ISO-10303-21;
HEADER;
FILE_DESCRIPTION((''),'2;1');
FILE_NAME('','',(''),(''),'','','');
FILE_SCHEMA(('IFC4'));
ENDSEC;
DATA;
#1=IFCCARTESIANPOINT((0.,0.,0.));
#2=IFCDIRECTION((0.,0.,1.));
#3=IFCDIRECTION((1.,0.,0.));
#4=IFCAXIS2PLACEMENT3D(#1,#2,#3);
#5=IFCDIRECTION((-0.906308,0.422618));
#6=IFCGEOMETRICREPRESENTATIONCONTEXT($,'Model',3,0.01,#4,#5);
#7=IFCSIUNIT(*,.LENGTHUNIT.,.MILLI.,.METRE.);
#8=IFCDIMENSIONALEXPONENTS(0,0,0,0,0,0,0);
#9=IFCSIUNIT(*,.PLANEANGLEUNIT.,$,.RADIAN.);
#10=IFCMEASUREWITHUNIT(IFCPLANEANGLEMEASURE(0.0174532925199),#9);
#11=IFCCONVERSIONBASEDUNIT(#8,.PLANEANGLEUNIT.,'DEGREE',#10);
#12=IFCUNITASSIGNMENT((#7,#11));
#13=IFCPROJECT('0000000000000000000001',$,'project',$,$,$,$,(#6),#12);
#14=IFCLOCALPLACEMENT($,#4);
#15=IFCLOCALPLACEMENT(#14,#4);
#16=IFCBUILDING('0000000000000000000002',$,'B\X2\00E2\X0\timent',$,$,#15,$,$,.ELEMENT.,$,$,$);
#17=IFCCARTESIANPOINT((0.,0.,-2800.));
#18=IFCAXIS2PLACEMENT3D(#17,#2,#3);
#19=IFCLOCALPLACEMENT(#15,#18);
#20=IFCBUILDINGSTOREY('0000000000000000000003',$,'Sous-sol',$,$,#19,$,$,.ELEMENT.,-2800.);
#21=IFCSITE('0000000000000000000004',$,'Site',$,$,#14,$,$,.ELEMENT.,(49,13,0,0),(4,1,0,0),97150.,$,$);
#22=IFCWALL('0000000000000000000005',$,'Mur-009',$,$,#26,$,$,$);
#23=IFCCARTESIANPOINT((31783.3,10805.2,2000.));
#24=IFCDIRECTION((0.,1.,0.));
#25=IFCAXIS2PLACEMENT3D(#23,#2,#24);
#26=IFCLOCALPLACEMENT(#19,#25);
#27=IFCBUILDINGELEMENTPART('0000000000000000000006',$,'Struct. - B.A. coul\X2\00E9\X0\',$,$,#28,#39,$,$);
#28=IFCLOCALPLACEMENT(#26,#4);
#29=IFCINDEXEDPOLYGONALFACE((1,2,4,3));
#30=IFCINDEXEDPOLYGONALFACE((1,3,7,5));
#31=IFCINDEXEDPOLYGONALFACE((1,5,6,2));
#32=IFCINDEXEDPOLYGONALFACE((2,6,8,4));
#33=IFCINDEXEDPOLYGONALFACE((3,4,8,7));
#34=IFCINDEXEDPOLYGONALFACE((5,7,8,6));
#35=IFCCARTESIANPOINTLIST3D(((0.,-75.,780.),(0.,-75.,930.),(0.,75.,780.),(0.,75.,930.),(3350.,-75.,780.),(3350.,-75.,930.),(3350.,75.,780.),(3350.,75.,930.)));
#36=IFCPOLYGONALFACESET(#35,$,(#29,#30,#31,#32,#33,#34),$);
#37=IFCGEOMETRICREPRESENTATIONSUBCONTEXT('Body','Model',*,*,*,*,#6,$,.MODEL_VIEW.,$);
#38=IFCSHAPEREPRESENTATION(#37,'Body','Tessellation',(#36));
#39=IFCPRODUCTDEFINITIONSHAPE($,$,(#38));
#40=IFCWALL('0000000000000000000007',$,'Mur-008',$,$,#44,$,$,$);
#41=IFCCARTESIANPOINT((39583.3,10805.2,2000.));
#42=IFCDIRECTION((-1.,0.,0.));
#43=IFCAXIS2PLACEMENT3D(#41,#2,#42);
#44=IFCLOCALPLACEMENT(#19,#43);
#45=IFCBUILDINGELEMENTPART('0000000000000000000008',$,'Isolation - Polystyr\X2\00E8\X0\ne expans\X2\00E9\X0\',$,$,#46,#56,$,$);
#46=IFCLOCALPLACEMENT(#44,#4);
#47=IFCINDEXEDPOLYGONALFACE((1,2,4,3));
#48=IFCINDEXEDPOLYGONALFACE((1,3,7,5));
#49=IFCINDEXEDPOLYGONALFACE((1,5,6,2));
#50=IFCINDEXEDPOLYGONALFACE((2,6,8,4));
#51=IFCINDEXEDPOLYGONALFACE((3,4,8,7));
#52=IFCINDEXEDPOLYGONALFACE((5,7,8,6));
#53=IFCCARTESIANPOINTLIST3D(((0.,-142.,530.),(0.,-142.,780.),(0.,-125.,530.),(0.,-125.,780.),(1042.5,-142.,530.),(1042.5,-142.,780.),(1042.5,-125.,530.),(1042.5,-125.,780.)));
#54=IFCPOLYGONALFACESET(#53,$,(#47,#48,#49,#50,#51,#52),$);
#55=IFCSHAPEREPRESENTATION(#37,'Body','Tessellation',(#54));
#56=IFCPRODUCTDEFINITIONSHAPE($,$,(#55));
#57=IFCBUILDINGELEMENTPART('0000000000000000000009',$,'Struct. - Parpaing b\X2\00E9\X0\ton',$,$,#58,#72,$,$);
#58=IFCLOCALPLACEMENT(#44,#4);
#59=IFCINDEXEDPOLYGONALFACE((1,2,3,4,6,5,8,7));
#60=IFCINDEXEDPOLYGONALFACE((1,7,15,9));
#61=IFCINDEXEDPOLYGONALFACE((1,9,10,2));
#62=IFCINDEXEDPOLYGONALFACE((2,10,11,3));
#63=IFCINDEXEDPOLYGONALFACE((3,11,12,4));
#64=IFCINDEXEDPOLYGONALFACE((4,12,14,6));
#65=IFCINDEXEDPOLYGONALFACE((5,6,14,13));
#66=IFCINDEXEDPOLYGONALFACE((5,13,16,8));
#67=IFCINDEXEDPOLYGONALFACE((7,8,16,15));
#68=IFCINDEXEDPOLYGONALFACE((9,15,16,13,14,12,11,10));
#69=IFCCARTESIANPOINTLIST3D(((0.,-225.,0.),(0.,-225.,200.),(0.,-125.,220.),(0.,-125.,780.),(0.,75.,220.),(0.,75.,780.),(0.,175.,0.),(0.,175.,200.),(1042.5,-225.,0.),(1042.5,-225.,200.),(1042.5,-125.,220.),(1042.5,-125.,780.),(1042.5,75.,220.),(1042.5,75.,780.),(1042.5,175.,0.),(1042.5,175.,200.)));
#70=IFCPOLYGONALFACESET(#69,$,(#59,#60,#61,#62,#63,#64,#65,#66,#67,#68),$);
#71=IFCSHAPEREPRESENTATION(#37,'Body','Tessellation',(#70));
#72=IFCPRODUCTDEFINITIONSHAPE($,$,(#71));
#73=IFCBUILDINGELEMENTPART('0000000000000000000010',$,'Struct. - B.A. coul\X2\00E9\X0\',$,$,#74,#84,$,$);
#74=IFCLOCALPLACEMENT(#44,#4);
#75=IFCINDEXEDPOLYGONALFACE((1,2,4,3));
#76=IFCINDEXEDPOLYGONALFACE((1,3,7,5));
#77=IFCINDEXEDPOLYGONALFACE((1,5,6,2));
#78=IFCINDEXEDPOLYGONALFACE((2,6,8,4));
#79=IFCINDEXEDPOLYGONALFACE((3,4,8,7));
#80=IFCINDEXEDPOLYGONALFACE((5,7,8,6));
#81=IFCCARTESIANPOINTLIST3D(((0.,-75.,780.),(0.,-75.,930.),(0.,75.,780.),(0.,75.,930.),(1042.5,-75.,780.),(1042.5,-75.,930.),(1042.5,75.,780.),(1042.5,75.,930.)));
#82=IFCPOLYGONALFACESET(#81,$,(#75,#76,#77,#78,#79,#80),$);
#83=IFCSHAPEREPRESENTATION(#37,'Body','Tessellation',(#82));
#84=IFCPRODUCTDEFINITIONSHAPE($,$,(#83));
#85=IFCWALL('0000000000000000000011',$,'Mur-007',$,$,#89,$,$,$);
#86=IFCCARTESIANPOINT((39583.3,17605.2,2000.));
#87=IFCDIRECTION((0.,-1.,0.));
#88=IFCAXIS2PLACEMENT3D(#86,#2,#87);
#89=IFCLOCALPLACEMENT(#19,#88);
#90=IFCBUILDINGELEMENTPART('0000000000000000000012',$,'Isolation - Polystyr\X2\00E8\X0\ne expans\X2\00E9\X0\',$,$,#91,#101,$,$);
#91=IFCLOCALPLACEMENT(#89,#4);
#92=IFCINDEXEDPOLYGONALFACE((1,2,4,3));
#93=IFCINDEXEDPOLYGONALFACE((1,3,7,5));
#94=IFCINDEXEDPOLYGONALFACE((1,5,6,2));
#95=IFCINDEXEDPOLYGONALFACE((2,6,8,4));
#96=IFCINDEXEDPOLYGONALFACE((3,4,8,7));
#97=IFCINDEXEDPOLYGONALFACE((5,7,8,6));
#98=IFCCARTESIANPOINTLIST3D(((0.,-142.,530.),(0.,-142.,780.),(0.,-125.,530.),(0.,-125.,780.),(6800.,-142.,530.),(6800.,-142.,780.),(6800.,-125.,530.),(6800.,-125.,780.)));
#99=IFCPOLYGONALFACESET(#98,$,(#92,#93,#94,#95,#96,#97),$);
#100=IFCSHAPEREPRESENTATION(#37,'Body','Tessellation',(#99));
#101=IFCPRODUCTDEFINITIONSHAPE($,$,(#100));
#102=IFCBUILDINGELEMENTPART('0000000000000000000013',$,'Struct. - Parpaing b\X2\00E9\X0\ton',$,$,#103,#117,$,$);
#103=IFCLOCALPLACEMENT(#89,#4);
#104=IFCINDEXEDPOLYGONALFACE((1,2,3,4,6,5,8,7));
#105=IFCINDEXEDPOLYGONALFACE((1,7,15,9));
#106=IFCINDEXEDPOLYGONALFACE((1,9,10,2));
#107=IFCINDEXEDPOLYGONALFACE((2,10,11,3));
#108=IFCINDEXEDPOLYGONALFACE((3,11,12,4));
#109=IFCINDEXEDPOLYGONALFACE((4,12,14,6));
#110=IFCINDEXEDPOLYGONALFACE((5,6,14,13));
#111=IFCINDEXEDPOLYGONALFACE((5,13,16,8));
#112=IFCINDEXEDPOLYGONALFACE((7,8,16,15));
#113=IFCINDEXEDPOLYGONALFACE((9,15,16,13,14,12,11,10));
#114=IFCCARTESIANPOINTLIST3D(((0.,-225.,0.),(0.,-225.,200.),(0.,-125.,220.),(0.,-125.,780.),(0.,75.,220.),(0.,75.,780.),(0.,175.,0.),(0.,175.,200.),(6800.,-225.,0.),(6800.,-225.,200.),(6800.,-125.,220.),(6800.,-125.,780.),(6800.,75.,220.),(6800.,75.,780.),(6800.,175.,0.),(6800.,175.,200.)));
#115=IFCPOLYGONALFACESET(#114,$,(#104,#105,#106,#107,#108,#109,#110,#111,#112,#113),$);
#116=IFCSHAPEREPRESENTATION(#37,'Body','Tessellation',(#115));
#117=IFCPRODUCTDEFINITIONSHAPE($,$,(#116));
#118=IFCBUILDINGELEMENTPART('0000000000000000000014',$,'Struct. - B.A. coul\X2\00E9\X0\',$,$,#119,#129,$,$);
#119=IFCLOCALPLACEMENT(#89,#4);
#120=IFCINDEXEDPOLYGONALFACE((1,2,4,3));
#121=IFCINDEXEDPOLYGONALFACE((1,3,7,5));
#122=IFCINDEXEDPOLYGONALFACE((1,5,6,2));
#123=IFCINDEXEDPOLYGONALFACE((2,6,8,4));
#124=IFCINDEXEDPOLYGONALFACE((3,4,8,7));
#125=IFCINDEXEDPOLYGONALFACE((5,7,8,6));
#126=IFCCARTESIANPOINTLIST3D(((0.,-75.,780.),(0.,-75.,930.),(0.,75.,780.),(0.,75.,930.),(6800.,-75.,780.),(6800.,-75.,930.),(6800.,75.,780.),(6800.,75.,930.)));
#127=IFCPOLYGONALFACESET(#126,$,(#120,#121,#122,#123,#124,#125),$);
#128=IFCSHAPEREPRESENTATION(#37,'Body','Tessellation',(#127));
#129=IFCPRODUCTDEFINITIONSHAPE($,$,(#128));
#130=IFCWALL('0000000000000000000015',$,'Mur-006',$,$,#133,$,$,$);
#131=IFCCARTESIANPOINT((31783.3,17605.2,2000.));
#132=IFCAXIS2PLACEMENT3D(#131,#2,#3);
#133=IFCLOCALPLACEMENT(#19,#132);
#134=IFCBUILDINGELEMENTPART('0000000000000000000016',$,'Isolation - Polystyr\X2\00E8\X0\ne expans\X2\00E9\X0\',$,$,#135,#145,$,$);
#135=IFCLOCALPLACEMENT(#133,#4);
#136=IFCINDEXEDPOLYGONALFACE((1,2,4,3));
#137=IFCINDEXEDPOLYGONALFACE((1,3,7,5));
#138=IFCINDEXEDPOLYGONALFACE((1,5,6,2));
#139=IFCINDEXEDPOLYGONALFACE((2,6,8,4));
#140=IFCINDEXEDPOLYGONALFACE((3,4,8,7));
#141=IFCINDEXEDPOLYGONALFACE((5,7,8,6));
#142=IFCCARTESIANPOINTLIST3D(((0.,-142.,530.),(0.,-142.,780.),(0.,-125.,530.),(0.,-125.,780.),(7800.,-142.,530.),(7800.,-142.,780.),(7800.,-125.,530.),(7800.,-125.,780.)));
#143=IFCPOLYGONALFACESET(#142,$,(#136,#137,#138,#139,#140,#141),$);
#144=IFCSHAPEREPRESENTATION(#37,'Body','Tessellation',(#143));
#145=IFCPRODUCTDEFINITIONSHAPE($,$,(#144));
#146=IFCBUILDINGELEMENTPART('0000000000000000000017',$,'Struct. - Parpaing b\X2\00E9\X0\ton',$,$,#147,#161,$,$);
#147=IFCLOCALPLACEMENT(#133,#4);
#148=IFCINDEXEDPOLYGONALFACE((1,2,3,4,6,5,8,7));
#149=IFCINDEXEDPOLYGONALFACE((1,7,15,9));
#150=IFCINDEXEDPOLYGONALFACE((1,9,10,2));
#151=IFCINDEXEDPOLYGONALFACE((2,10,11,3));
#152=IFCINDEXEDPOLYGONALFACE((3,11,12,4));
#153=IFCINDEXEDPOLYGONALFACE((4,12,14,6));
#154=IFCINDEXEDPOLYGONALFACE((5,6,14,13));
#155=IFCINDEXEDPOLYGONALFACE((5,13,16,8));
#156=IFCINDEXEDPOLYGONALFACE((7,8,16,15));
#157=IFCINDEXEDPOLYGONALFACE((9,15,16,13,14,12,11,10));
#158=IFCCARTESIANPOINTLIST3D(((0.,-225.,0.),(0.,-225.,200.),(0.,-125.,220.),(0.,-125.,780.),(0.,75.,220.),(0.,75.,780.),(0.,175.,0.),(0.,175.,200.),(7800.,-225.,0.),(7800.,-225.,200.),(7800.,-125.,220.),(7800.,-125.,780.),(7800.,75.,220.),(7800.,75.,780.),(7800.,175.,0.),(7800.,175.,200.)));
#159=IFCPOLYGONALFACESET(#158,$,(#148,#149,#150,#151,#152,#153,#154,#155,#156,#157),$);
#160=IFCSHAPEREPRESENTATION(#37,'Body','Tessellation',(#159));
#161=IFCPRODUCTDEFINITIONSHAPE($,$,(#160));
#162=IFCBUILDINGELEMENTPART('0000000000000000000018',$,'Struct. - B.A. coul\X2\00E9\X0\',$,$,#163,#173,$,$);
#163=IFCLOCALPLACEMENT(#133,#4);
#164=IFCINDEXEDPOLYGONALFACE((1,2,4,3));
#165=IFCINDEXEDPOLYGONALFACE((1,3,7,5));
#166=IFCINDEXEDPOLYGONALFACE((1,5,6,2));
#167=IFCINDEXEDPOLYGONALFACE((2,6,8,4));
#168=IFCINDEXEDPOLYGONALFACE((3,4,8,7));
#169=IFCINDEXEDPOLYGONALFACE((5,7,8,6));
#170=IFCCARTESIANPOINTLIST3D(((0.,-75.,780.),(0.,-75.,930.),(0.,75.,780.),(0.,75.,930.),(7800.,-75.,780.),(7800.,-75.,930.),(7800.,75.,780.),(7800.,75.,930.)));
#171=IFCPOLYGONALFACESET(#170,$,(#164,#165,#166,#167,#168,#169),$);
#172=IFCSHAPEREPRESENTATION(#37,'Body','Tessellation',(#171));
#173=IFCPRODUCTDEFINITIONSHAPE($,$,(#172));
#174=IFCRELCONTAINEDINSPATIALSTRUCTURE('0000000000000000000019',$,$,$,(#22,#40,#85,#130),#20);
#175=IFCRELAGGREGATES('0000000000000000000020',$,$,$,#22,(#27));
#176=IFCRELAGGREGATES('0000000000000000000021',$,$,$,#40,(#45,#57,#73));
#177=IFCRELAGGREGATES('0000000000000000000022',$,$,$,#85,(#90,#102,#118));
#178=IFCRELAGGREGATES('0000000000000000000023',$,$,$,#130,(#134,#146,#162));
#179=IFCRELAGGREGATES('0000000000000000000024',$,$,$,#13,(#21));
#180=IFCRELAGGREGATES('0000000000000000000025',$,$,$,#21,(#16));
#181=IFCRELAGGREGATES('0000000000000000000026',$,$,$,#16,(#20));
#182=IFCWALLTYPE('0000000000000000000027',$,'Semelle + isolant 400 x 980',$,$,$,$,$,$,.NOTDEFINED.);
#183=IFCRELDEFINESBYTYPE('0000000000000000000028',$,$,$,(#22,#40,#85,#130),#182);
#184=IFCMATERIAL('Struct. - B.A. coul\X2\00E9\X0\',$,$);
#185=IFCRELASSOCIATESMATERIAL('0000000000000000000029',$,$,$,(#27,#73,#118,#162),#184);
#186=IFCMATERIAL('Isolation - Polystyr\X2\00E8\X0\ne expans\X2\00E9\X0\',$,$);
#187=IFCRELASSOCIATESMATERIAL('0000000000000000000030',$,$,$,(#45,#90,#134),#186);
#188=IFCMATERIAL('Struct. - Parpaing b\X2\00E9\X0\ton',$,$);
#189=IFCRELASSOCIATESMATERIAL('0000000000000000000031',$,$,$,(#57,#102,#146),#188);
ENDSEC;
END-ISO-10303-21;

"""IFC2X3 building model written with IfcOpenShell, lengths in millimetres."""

from ifc_helpers import new_model, entity, si_unit, converted_unit, direction, frame, origin_with_axes, place, context, subcontext, project, spatial, polyline, outline, extrude, material, type_object, element, aggregate, save


model = new_model("IFC2X3")

# Units and contexts
model_context = context("Model", 3, precision=0.01, world=origin_with_axes(), true_north=direction((-0.906308, 0.422618)))
body_context = subcontext(model_context, "Body", "Model", "MODEL_VIEW")
ifc_project = project(units=[si_unit("LENGTHUNIT", "METRE", prefix="MILLI"), converted_unit("PLANEANGLEUNIT", "DEGREE", entity("IfcPlaneAngleMeasure", 0.0174532925199), si_unit("PLANEANGLEUNIT", "RADIAN"), dimensions=[0, 0, 0, 0, 0, 0, 0])], contexts=[model_context])

# Site, building, storey
site_placement = place(None, origin_with_axes())
site = spatial("IfcSite", under=ifc_project, at=site_placement, Name="Site", CompositionType="ELEMENT", RefLatitude=(49, 13, 0, 0), RefLongitude=(4, 1, 0, 0), RefElevation=97150.0)
building_placement = place(site_placement, origin_with_axes())
building = spatial("IfcBuilding", under=site, at=building_placement, Name="Bâtiment", CompositionType="ELEMENT")
storey_placement = place(building_placement, frame((0.0, 0.0, -2800.0), z_axis=(0.0, 0.0, 1.0), x_axis=(1.0, 0.0, 0.0)))
storey = spatial("IfcBuildingStorey", under=building, at=storey_placement, Name="Sous-sol", CompositionType="ELEMENT", Elevation=-2800.0)

# Walls, building element parts
ifc_material_1 = material(Name="Isolation - Polystyrène expansé")
ifc_material_2 = material(Name="Struct. - Parpaing béton")
wall_type_1 = type_object("IfcWallType", Name="Semelle + isolant 400 x 980", PredefinedType="NOTDEFINED")
ifc_material_3 = material(Name="Struct. - B.A. coulé")
wall_1_placement = place(storey_placement, frame((31783.3, 10805.2, 2000.0), z_axis=(0.0, 0.0, 1.0), x_axis=(0.0, 1.0, 0.0)))
wall_1 = element("IfcWall", 1, at=wall_1_placement, inside=storey, type_object=wall_type_1, Name="Mur-009")
building_element_part_1_placement = place(wall_1_placement, origin_with_axes())
building_element_part_1 = element("IfcBuildingElementPart", 2, at=building_element_part_1_placement, material=ifc_material_3, Name="Struct. - B.A. coulé", context=body_context, shape_type="SweptSolid", body=[
    extrude(outline(polyline([(75.0, 780.0), (75.0, 930.0), (-75.0, 930.0), (-75.0, 780.0), (75.0, 780.0)])), frame((0.0, 0.0, 0.0), z_axis=(-1.0, 0.0, 0.0), x_axis=(0.0, -1.0, 0.0)), (0.0, 0.0, -1.0), 3350.0),
])
aggregate(wall_1, [building_element_part_1])
wall_2_placement = place(storey_placement, frame((39583.3, 10805.2, 2000.0), z_axis=(0.0, 0.0, 1.0), x_axis=(-1.0, 0.0, 0.0)))
wall_2 = element("IfcWall", 3, at=wall_2_placement, inside=storey, type_object=wall_type_1, Name="Mur-008")
building_element_part_2_placement = place(wall_2_placement, origin_with_axes())
building_element_part_2 = element("IfcBuildingElementPart", 4, at=building_element_part_2_placement, material=ifc_material_1, Name="Isolation - Polystyrène expansé", context=body_context, shape_type="SweptSolid", body=[
    extrude(outline(polyline([(125.0, 780.0), (125.0, 530.0), (142.0, 530.0), (142.0, 780.0), (125.0, 780.0)])), frame((0.0, 0.0, 0.0), z_axis=(-1.0, 0.0, 0.0), x_axis=(0.0, -1.0, 0.0)), (0.0, 0.0, -1.0), 1042.5),
])
building_element_part_3_placement = place(wall_2_placement, origin_with_axes())
building_element_part_3 = element("IfcBuildingElementPart", 5, at=building_element_part_3_placement, material=ifc_material_2, Name="Struct. - Parpaing béton", context=body_context, shape_type="SweptSolid", body=[
    extrude(outline(polyline([(-75.0, 220.0), (-175.0, 200.0), (-175.0, 0.0), (225.0, 0.0), (225.0, 200.0), (125.0, 220.0), (125.0, 780.0), (-75.0, 780.0), (-75.0, 220.0)])), frame((0.0, 0.0, 0.0), z_axis=(-1.0, 0.0, 0.0), x_axis=(0.0, -1.0, 0.0)), (0.0, 0.0, -1.0), 1042.5),
])
building_element_part_4_placement = place(wall_2_placement, origin_with_axes())
building_element_part_4 = element("IfcBuildingElementPart", 6, at=building_element_part_4_placement, material=ifc_material_3, Name="Struct. - B.A. coulé", context=body_context, shape_type="SweptSolid", body=[
    extrude(outline(polyline([(75.0, 780.0), (75.0, 930.0), (-75.0, 930.0), (-75.0, 780.0), (75.0, 780.0)])), frame((0.0, 0.0, 0.0), z_axis=(-1.0, 0.0, 0.0), x_axis=(0.0, -1.0, 0.0)), (0.0, 0.0, -1.0), 1042.5),
])
aggregate(wall_2, [building_element_part_2, building_element_part_3, building_element_part_4])
wall_3_placement = place(storey_placement, frame((39583.3, 17605.2, 2000.0), z_axis=(0.0, 0.0, 1.0), x_axis=(0.0, -1.0, 0.0)))
wall_3 = element("IfcWall", 7, at=wall_3_placement, inside=storey, type_object=wall_type_1, Name="Mur-007")
building_element_part_5_placement = place(wall_3_placement, origin_with_axes())
building_element_part_5 = element("IfcBuildingElementPart", 8, at=building_element_part_5_placement, material=ifc_material_1, Name="Isolation - Polystyrène expansé", context=body_context, shape_type="SweptSolid", body=[
    extrude(outline(polyline([(125.0, 780.0), (125.0, 530.0), (142.0, 530.0), (142.0, 780.0), (125.0, 780.0)])), frame((0.0, 0.0, 0.0), z_axis=(-1.0, 0.0, 0.0), x_axis=(0.0, -1.0, 0.0)), (0.0, 0.0, -1.0), 6800.0),
])
building_element_part_6_placement = place(wall_3_placement, origin_with_axes())
building_element_part_6 = element("IfcBuildingElementPart", 9, at=building_element_part_6_placement, material=ifc_material_2, Name="Struct. - Parpaing béton", context=body_context, shape_type="SweptSolid", body=[
    extrude(outline(polyline([(-75.0, 220.0), (-175.0, 200.0), (-175.0, 0.0), (225.0, 0.0), (225.0, 200.0), (125.0, 220.0), (125.0, 780.0), (-75.0, 780.0), (-75.0, 220.0)])), frame((0.0, 0.0, 0.0), z_axis=(-1.0, 0.0, 0.0), x_axis=(0.0, -1.0, 0.0)), (0.0, 0.0, -1.0), 6800.0),
])
building_element_part_7_placement = place(wall_3_placement, origin_with_axes())
building_element_part_7 = element("IfcBuildingElementPart", 10, at=building_element_part_7_placement, material=ifc_material_3, Name="Struct. - B.A. coulé", context=body_context, shape_type="SweptSolid", body=[
    extrude(outline(polyline([(75.0, 780.0), (75.0, 930.0), (-75.0, 930.0), (-75.0, 780.0), (75.0, 780.0)])), frame((0.0, 0.0, 0.0), z_axis=(-1.0, 0.0, 0.0), x_axis=(0.0, -1.0, 0.0)), (0.0, 0.0, -1.0), 6800.0),
])
aggregate(wall_3, [building_element_part_5, building_element_part_6, building_element_part_7])
wall_4_placement = place(storey_placement, frame((31783.3, 17605.2, 2000.0), z_axis=(0.0, 0.0, 1.0), x_axis=(1.0, 0.0, 0.0)))
wall_4 = element("IfcWall", 11, at=wall_4_placement, inside=storey, type_object=wall_type_1, Name="Mur-006")
building_element_part_8_placement = place(wall_4_placement, origin_with_axes())
building_element_part_8 = element("IfcBuildingElementPart", 12, at=building_element_part_8_placement, material=ifc_material_1, Name="Isolation - Polystyrène expansé", context=body_context, shape_type="SweptSolid", body=[
    extrude(outline(polyline([(125.0, 780.0), (125.0, 530.0), (142.0, 530.0), (142.0, 780.0), (125.0, 780.0)])), frame((0.0, 0.0, 0.0), z_axis=(-1.0, 0.0, 0.0), x_axis=(0.0, -1.0, 0.0)), (0.0, 0.0, -1.0), 7800.0),
])
building_element_part_9_placement = place(wall_4_placement, origin_with_axes())
building_element_part_9 = element("IfcBuildingElementPart", 13, at=building_element_part_9_placement, material=ifc_material_2, Name="Struct. - Parpaing béton", context=body_context, shape_type="SweptSolid", body=[
    extrude(outline(polyline([(-75.0, 220.0), (-175.0, 200.0), (-175.0, 0.0), (225.0, 0.0), (225.0, 200.0), (125.0, 220.0), (125.0, 780.0), (-75.0, 780.0), (-75.0, 220.0)])), frame((0.0, 0.0, 0.0), z_axis=(-1.0, 0.0, 0.0), x_axis=(0.0, -1.0, 0.0)), (0.0, 0.0, -1.0), 7800.0),
])
building_element_part_10_placement = place(wall_4_placement, origin_with_axes())
building_element_part_10 = element("IfcBuildingElementPart", 14, at=building_element_part_10_placement, material=ifc_material_3, Name="Struct. - B.A. coulé", context=body_context, shape_type="SweptSolid", body=[
    extrude(outline(polyline([(75.0, 780.0), (75.0, 930.0), (-75.0, 930.0), (-75.0, 780.0), (75.0, 780.0)])), frame((0.0, 0.0, 0.0), z_axis=(-1.0, 0.0, 0.0), x_axis=(0.0, -1.0, 0.0)), (0.0, 0.0, -1.0), 7800.0),
])
aggregate(wall_4, [building_element_part_8, building_element_part_9, building_element_part_10])

save(model, "model.ifc")
